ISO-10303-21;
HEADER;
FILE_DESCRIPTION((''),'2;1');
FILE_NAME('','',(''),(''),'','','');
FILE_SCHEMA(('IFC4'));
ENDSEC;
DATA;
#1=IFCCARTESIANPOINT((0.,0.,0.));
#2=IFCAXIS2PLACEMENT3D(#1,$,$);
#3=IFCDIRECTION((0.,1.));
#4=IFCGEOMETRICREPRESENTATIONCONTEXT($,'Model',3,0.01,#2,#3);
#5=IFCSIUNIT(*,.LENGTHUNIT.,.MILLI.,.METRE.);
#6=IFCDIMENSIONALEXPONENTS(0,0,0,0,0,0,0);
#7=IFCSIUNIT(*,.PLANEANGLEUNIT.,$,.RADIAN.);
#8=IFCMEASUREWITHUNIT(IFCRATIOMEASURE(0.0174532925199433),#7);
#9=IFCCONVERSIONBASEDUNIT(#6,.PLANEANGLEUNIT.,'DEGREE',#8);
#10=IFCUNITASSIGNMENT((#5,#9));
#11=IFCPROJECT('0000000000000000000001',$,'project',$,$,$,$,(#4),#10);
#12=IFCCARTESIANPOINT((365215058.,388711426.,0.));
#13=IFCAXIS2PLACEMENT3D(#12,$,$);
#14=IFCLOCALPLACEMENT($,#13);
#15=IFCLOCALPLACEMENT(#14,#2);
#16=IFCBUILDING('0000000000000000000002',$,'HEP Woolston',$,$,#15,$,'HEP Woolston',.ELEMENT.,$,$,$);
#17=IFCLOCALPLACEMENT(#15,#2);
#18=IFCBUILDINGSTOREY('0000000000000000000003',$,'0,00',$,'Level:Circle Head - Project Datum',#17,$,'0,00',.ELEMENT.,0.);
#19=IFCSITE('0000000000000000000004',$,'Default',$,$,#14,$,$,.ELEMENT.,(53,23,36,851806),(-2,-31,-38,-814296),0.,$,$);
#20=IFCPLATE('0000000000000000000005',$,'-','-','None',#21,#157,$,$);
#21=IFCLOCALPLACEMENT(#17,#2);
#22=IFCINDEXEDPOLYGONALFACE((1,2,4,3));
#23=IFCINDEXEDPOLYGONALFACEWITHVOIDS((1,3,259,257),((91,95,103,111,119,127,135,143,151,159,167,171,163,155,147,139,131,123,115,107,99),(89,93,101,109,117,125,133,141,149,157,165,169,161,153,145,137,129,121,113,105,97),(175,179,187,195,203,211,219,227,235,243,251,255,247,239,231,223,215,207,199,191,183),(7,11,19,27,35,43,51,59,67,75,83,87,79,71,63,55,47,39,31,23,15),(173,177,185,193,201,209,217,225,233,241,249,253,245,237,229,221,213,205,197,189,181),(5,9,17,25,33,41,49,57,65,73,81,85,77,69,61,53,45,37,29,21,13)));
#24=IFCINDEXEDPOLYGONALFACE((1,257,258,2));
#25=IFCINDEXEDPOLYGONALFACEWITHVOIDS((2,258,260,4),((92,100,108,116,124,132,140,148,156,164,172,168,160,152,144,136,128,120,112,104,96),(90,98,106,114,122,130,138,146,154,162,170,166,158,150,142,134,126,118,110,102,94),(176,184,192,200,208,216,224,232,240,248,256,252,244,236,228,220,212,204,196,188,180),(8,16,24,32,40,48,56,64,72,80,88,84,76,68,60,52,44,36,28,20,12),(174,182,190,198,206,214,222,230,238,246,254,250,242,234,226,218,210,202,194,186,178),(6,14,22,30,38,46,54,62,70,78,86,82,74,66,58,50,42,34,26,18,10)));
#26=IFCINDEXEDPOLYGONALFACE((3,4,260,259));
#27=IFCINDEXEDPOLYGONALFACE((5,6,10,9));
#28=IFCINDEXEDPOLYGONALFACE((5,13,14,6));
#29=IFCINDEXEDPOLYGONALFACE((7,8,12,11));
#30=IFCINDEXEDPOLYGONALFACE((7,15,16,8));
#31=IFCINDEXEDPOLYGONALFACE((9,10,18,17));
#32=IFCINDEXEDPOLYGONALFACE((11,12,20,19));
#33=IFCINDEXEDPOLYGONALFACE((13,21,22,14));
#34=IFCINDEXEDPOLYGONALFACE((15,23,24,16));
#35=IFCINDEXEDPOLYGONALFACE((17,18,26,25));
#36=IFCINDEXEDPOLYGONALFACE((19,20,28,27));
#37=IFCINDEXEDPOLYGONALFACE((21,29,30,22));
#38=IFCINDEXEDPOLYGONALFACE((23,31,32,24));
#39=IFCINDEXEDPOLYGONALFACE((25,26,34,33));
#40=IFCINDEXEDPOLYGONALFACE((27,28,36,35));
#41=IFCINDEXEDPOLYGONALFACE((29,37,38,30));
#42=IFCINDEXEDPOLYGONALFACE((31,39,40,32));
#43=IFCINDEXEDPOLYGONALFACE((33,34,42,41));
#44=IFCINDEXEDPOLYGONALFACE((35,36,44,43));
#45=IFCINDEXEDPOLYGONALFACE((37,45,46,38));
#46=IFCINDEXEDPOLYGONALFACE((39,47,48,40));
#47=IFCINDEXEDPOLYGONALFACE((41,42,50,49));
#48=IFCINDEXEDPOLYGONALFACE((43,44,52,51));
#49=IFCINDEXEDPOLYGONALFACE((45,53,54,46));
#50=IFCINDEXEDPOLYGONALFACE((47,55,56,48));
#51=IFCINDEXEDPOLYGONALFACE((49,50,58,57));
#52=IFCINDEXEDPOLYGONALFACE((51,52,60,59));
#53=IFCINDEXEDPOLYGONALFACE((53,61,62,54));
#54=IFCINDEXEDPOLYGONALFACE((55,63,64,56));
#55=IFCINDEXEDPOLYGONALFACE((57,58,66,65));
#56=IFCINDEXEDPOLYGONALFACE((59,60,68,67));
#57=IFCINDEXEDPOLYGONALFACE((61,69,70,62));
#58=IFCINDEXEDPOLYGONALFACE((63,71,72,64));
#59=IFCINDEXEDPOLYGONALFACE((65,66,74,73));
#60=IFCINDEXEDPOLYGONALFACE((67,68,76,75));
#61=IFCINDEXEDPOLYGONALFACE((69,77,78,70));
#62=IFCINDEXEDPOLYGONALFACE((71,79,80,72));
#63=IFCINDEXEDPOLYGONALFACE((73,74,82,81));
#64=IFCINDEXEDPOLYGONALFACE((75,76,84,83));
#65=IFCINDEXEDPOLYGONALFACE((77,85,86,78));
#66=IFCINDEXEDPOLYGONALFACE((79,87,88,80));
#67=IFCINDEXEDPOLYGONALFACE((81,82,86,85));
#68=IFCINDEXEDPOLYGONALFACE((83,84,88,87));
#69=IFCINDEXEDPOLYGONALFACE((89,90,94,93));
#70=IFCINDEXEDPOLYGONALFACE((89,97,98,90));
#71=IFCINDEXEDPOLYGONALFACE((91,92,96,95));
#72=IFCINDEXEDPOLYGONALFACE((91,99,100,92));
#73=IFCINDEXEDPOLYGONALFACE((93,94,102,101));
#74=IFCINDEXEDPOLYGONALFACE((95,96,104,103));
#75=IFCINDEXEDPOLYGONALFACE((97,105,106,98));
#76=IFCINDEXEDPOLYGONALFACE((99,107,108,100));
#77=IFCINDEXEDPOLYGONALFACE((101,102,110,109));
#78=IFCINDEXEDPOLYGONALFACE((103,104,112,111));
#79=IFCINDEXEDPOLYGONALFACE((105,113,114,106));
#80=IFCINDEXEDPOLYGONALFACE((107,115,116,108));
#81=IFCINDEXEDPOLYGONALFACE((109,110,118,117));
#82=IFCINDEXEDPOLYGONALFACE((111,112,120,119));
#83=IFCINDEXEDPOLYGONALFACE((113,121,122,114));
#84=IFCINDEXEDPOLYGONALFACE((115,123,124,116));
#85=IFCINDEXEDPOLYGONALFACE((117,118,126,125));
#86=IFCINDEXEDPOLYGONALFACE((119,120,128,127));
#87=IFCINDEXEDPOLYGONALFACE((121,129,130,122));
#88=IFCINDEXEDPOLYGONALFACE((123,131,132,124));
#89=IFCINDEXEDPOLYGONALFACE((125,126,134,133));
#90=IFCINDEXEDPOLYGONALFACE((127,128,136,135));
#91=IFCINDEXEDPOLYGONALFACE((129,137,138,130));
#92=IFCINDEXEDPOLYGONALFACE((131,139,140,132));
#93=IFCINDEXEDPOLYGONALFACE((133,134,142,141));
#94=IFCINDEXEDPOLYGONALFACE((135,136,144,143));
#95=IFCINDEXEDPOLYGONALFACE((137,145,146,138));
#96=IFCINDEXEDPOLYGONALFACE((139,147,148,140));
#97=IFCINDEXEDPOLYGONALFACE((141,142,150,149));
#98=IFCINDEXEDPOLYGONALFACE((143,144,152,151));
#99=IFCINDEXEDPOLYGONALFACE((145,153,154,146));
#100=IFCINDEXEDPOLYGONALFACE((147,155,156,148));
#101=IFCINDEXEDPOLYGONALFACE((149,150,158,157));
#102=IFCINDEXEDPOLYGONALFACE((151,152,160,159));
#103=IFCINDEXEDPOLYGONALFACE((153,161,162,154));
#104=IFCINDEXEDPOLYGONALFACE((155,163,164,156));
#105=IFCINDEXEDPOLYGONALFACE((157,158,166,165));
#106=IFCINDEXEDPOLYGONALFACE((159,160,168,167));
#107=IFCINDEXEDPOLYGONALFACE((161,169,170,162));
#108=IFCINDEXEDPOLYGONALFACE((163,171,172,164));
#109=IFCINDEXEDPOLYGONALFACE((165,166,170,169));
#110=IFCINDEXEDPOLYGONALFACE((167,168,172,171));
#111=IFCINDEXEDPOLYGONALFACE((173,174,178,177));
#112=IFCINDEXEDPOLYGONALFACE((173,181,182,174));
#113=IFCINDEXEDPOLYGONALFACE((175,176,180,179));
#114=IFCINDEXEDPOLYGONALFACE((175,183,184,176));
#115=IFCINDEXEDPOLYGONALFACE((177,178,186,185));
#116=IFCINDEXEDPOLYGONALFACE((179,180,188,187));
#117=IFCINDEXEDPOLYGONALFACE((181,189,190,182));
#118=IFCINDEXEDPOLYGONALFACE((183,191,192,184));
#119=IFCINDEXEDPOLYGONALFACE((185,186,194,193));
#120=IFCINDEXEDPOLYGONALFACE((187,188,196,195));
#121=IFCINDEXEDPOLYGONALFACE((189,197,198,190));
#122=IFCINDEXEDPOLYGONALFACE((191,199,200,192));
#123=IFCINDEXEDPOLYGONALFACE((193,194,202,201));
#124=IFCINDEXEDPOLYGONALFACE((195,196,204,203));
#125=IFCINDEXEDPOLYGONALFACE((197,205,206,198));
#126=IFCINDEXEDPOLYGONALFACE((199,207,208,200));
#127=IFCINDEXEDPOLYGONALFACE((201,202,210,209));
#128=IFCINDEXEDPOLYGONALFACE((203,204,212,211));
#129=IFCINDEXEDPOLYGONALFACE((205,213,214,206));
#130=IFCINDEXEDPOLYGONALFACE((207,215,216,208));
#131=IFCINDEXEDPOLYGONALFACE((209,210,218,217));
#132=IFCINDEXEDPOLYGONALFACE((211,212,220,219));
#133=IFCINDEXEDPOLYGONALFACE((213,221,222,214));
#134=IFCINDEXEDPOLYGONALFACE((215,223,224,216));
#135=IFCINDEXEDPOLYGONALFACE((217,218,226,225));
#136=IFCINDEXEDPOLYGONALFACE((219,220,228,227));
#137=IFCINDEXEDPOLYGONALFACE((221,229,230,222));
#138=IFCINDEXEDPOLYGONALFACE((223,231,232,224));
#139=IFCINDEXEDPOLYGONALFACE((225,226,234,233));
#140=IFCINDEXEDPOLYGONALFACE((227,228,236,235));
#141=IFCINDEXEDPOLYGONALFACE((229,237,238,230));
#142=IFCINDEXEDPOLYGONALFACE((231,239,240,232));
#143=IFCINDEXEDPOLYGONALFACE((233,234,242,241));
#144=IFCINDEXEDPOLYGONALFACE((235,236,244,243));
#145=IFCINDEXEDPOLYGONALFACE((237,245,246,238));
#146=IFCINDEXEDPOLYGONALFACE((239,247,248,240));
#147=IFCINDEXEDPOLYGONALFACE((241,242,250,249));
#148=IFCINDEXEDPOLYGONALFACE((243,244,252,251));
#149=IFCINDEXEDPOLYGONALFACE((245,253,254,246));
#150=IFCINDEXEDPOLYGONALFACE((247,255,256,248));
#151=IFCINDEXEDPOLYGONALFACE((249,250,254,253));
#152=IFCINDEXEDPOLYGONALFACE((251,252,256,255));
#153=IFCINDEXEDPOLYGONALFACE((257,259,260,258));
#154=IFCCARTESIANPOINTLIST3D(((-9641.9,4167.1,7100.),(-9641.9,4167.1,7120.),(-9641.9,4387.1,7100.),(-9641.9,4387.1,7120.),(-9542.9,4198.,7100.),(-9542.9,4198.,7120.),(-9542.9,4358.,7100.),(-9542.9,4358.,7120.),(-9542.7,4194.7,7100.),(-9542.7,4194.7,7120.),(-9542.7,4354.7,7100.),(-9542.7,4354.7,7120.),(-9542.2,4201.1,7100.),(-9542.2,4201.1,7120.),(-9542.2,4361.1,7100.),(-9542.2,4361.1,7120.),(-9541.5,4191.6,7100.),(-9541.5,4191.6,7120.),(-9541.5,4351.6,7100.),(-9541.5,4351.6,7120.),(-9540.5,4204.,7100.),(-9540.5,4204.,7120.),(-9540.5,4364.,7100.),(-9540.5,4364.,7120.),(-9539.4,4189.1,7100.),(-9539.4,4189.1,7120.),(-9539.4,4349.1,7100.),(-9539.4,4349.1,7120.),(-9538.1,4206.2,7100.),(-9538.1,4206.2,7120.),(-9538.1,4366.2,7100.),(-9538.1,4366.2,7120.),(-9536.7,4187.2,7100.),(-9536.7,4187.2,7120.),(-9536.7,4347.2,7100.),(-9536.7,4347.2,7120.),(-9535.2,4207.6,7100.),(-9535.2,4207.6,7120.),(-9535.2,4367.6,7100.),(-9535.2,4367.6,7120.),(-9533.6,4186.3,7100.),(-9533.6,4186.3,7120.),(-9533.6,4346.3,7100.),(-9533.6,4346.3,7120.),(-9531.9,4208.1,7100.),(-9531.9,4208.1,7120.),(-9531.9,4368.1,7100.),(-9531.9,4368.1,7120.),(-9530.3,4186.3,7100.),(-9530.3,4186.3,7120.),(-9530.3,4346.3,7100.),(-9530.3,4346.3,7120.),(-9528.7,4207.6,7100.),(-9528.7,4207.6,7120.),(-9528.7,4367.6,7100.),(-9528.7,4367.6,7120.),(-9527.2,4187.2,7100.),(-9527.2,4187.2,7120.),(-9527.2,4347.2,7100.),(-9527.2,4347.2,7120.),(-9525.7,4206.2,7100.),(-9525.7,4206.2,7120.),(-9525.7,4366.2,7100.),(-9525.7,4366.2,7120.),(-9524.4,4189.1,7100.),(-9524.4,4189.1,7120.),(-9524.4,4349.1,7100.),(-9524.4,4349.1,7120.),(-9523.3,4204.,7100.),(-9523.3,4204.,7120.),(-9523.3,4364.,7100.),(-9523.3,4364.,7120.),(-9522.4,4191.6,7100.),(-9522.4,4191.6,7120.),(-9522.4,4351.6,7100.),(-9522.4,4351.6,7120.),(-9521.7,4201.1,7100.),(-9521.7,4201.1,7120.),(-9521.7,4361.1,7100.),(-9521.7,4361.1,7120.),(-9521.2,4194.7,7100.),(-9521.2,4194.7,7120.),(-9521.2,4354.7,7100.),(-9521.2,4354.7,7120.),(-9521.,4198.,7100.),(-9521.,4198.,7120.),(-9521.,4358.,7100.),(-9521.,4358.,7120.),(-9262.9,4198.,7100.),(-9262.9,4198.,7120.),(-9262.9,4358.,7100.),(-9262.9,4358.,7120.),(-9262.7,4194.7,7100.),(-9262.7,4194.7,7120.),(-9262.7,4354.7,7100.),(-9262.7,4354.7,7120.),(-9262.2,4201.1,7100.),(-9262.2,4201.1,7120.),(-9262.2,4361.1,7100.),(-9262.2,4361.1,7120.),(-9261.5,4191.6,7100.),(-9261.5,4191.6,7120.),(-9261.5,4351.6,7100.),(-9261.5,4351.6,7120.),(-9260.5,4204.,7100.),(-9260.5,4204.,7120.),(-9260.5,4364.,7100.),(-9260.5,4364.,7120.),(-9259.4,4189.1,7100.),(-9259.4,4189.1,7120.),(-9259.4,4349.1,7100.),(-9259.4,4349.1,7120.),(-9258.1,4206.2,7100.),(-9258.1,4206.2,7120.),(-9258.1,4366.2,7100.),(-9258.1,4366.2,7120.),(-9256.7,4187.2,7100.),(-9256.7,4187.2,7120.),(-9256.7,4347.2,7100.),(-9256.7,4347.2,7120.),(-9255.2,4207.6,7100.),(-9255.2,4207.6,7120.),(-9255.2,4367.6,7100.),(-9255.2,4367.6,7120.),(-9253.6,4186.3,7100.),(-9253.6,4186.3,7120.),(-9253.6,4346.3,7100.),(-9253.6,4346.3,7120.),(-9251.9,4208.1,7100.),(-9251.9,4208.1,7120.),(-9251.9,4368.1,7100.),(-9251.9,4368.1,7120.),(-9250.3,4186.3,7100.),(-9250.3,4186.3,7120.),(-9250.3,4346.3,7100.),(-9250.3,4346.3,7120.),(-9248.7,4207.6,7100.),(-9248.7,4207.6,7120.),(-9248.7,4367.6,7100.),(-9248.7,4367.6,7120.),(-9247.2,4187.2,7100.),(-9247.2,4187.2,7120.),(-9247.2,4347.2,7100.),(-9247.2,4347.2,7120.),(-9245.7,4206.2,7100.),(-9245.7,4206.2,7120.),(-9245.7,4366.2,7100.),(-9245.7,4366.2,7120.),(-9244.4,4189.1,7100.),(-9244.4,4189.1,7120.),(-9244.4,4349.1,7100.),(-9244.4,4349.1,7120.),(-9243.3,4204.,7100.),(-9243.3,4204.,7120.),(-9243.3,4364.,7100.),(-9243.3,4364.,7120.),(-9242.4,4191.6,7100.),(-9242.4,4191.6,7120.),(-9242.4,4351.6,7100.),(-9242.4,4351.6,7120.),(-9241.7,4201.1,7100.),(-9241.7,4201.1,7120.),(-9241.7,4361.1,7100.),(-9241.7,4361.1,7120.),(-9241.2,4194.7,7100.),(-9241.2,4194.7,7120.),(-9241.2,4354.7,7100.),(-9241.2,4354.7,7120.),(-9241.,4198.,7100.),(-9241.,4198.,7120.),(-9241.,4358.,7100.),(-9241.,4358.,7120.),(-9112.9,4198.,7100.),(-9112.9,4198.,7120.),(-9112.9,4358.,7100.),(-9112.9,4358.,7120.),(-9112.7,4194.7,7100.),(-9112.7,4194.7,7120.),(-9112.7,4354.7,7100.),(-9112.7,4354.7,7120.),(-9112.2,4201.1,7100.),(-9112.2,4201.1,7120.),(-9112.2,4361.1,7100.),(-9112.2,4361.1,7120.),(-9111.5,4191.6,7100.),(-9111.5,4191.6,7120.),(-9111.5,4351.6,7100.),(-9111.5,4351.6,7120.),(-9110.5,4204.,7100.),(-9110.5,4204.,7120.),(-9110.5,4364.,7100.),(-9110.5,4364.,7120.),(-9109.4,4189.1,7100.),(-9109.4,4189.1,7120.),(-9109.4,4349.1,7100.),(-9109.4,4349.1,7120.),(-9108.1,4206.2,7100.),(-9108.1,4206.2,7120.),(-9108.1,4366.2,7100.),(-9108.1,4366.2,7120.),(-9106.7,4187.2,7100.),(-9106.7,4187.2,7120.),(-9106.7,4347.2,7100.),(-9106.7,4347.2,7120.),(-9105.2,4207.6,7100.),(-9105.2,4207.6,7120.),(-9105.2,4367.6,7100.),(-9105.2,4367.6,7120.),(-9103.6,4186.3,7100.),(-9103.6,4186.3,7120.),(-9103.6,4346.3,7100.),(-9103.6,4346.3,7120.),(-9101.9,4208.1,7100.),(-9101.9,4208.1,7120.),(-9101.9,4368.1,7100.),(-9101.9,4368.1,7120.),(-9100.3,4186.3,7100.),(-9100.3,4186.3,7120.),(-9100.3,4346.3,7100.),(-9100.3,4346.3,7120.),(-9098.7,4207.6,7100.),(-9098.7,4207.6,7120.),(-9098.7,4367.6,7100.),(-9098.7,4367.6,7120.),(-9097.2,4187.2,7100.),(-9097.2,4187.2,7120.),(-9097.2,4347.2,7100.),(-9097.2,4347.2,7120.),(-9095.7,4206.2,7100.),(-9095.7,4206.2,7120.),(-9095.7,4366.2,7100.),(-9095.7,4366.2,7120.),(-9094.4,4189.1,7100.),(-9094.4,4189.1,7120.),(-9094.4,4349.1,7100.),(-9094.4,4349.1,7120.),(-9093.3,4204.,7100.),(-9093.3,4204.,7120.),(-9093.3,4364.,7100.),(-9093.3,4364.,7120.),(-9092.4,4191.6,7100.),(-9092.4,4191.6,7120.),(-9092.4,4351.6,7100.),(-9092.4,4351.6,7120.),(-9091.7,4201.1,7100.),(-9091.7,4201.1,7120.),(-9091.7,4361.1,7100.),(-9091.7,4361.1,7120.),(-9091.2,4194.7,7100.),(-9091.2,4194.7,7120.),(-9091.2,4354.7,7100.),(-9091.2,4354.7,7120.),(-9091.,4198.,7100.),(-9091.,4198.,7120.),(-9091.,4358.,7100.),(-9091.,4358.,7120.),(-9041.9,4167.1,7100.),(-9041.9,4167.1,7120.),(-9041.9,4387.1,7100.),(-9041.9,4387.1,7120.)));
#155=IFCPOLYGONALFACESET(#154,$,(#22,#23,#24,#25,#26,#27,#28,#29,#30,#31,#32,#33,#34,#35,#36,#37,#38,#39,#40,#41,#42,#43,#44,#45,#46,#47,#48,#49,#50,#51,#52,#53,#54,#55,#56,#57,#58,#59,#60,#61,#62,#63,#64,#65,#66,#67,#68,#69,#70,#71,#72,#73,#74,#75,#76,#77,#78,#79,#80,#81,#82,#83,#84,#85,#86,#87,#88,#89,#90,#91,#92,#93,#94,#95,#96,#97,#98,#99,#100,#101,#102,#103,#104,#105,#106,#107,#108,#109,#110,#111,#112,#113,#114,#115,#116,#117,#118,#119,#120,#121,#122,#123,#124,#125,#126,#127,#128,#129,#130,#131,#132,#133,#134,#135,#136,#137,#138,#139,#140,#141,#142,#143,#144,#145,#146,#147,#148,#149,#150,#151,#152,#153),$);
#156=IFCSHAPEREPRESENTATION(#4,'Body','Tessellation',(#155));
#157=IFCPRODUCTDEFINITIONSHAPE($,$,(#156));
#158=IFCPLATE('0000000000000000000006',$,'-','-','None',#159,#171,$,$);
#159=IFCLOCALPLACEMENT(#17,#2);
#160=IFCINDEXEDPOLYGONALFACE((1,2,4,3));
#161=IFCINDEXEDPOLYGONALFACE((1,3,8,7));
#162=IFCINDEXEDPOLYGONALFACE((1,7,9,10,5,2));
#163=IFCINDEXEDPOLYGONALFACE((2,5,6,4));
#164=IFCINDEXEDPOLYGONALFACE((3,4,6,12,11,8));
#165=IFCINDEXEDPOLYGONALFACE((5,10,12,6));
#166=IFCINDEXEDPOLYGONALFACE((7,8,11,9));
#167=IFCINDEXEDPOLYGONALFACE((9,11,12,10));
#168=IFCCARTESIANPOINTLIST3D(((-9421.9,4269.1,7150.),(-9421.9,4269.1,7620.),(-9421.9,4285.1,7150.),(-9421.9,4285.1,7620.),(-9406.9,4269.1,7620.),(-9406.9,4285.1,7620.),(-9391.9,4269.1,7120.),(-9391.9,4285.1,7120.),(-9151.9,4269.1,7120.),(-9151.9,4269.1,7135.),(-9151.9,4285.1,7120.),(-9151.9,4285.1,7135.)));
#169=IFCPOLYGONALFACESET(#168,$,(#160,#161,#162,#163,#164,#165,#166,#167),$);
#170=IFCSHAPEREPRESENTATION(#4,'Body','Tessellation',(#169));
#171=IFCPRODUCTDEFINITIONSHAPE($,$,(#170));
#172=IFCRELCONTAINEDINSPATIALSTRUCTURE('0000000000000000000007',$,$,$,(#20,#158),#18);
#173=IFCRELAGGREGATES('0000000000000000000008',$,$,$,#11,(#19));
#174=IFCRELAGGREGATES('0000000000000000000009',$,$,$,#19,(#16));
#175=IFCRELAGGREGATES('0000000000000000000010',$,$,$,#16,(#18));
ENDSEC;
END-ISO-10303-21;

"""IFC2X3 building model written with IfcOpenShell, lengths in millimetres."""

from ifc_helpers import new_model, entity, si_unit, converted_unit, direction, frame, frame_2d, origin, origin_with_axes, place, context, project, spatial, polyline, circle, outline, extrude, element, save


model = new_model("IFC2X3")

# Units and contexts
model_context = context("Model", 3, precision=0.01, world=origin(), true_north=direction((0.0, 1.0)))
ifc_project = project(units=[si_unit("LENGTHUNIT", "METRE", prefix="MILLI"), converted_unit("PLANEANGLEUNIT", "DEGREE", entity("IfcRatioMeasure", 0.0174532925199433), si_unit("PLANEANGLEUNIT", "RADIAN"), dimensions=[0, 0, 0, 0, 0, 0, 0])], contexts=[model_context])

# Site, building, storey
site_placement = place(None, frame((365215058.0, 388711426.0, 0.0)))
site = spatial("IfcSite", under=ifc_project, at=site_placement, Name="Default", CompositionType="ELEMENT", RefLatitude=(53, 23, 36, 851806), RefLongitude=(-2, -31, -38, -814296), RefElevation=0.0)
building_placement = place(site_placement, origin())
building = spatial("IfcBuilding", under=site, at=building_placement, Name="HEP Woolston", LongName="HEP Woolston", CompositionType="ELEMENT")
storey_placement = place(building_placement, origin())
storey = spatial("IfcBuildingStorey", under=building, at=storey_placement, Name="0,00", ObjectType="Level:Circle Head - Project Datum", LongName="0,00", CompositionType="ELEMENT", Elevation=0.0)

# Plate, openings
plate_1_placement = place(storey_placement, frame((-9041.9, 4387.1, 7100.0)))
plate_1 = element("IfcPlate", 1, at=plate_1_placement, inside=storey, Name="-", Description="-", ObjectType="None", context=model_context, shape_type="SweptSolid", body=[
    extrude(outline(polyline([(0.0, 0.0), (-600.0, 0.0), (-600.0, -220.0), (0.0, -220.0), (0.0, 0.0)])), origin_with_axes(), (0.0, 0.0, 1.0), 20.0),
])
opening_1_placement = place(plate_1_placement, frame((-490.0, -110.0, -0.5), z_axis=(0.0, 0.0, 1.0), x_axis=(0.0, 1.0, 0.0)))
element("IfcOpeningElement", 2, at=opening_1_placement, cuts=plate_1, ObjectType="Opening", context=model_context, shape_type="SweptSolid", body=[
    extrude(circle(Radius=11.0, at=frame_2d((80.0, 0.0), x_axis=(1.0, 0.0))), origin(), (0.0, 0.0, 1.0), 21.0),
])
opening_2_placement = place(plate_1_placement, frame((-490.0, -110.0, -0.5), z_axis=(0.0, 0.0, 1.0), x_axis=(0.0, 1.0, 0.0)))
element("IfcOpeningElement", 3, at=opening_2_placement, cuts=plate_1, ObjectType="Opening", context=model_context, shape_type="SweptSolid", body=[
    extrude(circle(Radius=11.0, at=frame_2d((-80.0, 0.0), x_axis=(1.0, 0.0))), origin(), (0.0, 0.0, 1.0), 21.0),
])
opening_3_placement = place(plate_1_placement, frame((-135.0, -110.0, -0.5), z_axis=(0.0, 0.0, 1.0), x_axis=(0.0, 1.0, 0.0)))
element("IfcOpeningElement", 4, at=opening_3_placement, cuts=plate_1, ObjectType="Opening", context=model_context, shape_type="SweptSolid", body=[
    extrude(circle(Radius=11.0, at=frame_2d((80.0, 75.0), x_axis=(1.0, 0.0))), origin(), (0.0, 0.0, 1.0), 21.0),
])
opening_4_placement = place(plate_1_placement, frame((-135.0, -110.0, -0.5), z_axis=(0.0, 0.0, 1.0), x_axis=(0.0, 1.0, 0.0)))
element("IfcOpeningElement", 5, at=opening_4_placement, cuts=plate_1, ObjectType="Opening", context=model_context, shape_type="SweptSolid", body=[
    extrude(circle(Radius=11.0, at=frame_2d((-80.0, 75.0), x_axis=(1.0, 0.0))), origin(), (0.0, 0.0, 1.0), 21.0),
])
opening_5_placement = place(plate_1_placement, frame((-135.0, -110.0, -0.5), z_axis=(0.0, 0.0, 1.0), x_axis=(0.0, 1.0, 0.0)))
element("IfcOpeningElement", 6, at=opening_5_placement, cuts=plate_1, ObjectType="Opening", context=model_context, shape_type="SweptSolid", body=[
    extrude(circle(Radius=11.0, at=frame_2d((80.0, -75.0), x_axis=(1.0, 0.0))), origin(), (0.0, 0.0, 1.0), 21.0),
])
opening_6_placement = place(plate_1_placement, frame((-135.0, -110.0, -0.5), z_axis=(0.0, 0.0, 1.0), x_axis=(0.0, 1.0, 0.0)))
element("IfcOpeningElement", 7, at=opening_6_placement, cuts=plate_1, ObjectType="Opening", context=model_context, shape_type="SweptSolid", body=[
    extrude(circle(Radius=11.0, at=frame_2d((-80.0, -75.0), x_axis=(1.0, 0.0))), origin(), (0.0, 0.0, 1.0), 21.0),
])

# Plate
plate_2_placement = place(storey_placement, frame((-9421.9, 4285.1, 7620.0), z_axis=(0.0, -1.0, 0.0), x_axis=(1.0, 0.0, 0.0)))
element("IfcPlate", 8, at=plate_2_placement, inside=storey, Name="-", Description="-", ObjectType="None", context=model_context, shape_type="SweptSolid", body=[
    extrude(outline(polyline([(0.0, -470.0), (30.0, -500.0), (270.0, -500.0), (270.0, -485.0), (15.0, 0.0), (0.0, 0.0), (0.0, -470.0)])), origin_with_axes(), (0.0, 0.0, 1.0), 16.0),
])

save(model, "model.ifc")
